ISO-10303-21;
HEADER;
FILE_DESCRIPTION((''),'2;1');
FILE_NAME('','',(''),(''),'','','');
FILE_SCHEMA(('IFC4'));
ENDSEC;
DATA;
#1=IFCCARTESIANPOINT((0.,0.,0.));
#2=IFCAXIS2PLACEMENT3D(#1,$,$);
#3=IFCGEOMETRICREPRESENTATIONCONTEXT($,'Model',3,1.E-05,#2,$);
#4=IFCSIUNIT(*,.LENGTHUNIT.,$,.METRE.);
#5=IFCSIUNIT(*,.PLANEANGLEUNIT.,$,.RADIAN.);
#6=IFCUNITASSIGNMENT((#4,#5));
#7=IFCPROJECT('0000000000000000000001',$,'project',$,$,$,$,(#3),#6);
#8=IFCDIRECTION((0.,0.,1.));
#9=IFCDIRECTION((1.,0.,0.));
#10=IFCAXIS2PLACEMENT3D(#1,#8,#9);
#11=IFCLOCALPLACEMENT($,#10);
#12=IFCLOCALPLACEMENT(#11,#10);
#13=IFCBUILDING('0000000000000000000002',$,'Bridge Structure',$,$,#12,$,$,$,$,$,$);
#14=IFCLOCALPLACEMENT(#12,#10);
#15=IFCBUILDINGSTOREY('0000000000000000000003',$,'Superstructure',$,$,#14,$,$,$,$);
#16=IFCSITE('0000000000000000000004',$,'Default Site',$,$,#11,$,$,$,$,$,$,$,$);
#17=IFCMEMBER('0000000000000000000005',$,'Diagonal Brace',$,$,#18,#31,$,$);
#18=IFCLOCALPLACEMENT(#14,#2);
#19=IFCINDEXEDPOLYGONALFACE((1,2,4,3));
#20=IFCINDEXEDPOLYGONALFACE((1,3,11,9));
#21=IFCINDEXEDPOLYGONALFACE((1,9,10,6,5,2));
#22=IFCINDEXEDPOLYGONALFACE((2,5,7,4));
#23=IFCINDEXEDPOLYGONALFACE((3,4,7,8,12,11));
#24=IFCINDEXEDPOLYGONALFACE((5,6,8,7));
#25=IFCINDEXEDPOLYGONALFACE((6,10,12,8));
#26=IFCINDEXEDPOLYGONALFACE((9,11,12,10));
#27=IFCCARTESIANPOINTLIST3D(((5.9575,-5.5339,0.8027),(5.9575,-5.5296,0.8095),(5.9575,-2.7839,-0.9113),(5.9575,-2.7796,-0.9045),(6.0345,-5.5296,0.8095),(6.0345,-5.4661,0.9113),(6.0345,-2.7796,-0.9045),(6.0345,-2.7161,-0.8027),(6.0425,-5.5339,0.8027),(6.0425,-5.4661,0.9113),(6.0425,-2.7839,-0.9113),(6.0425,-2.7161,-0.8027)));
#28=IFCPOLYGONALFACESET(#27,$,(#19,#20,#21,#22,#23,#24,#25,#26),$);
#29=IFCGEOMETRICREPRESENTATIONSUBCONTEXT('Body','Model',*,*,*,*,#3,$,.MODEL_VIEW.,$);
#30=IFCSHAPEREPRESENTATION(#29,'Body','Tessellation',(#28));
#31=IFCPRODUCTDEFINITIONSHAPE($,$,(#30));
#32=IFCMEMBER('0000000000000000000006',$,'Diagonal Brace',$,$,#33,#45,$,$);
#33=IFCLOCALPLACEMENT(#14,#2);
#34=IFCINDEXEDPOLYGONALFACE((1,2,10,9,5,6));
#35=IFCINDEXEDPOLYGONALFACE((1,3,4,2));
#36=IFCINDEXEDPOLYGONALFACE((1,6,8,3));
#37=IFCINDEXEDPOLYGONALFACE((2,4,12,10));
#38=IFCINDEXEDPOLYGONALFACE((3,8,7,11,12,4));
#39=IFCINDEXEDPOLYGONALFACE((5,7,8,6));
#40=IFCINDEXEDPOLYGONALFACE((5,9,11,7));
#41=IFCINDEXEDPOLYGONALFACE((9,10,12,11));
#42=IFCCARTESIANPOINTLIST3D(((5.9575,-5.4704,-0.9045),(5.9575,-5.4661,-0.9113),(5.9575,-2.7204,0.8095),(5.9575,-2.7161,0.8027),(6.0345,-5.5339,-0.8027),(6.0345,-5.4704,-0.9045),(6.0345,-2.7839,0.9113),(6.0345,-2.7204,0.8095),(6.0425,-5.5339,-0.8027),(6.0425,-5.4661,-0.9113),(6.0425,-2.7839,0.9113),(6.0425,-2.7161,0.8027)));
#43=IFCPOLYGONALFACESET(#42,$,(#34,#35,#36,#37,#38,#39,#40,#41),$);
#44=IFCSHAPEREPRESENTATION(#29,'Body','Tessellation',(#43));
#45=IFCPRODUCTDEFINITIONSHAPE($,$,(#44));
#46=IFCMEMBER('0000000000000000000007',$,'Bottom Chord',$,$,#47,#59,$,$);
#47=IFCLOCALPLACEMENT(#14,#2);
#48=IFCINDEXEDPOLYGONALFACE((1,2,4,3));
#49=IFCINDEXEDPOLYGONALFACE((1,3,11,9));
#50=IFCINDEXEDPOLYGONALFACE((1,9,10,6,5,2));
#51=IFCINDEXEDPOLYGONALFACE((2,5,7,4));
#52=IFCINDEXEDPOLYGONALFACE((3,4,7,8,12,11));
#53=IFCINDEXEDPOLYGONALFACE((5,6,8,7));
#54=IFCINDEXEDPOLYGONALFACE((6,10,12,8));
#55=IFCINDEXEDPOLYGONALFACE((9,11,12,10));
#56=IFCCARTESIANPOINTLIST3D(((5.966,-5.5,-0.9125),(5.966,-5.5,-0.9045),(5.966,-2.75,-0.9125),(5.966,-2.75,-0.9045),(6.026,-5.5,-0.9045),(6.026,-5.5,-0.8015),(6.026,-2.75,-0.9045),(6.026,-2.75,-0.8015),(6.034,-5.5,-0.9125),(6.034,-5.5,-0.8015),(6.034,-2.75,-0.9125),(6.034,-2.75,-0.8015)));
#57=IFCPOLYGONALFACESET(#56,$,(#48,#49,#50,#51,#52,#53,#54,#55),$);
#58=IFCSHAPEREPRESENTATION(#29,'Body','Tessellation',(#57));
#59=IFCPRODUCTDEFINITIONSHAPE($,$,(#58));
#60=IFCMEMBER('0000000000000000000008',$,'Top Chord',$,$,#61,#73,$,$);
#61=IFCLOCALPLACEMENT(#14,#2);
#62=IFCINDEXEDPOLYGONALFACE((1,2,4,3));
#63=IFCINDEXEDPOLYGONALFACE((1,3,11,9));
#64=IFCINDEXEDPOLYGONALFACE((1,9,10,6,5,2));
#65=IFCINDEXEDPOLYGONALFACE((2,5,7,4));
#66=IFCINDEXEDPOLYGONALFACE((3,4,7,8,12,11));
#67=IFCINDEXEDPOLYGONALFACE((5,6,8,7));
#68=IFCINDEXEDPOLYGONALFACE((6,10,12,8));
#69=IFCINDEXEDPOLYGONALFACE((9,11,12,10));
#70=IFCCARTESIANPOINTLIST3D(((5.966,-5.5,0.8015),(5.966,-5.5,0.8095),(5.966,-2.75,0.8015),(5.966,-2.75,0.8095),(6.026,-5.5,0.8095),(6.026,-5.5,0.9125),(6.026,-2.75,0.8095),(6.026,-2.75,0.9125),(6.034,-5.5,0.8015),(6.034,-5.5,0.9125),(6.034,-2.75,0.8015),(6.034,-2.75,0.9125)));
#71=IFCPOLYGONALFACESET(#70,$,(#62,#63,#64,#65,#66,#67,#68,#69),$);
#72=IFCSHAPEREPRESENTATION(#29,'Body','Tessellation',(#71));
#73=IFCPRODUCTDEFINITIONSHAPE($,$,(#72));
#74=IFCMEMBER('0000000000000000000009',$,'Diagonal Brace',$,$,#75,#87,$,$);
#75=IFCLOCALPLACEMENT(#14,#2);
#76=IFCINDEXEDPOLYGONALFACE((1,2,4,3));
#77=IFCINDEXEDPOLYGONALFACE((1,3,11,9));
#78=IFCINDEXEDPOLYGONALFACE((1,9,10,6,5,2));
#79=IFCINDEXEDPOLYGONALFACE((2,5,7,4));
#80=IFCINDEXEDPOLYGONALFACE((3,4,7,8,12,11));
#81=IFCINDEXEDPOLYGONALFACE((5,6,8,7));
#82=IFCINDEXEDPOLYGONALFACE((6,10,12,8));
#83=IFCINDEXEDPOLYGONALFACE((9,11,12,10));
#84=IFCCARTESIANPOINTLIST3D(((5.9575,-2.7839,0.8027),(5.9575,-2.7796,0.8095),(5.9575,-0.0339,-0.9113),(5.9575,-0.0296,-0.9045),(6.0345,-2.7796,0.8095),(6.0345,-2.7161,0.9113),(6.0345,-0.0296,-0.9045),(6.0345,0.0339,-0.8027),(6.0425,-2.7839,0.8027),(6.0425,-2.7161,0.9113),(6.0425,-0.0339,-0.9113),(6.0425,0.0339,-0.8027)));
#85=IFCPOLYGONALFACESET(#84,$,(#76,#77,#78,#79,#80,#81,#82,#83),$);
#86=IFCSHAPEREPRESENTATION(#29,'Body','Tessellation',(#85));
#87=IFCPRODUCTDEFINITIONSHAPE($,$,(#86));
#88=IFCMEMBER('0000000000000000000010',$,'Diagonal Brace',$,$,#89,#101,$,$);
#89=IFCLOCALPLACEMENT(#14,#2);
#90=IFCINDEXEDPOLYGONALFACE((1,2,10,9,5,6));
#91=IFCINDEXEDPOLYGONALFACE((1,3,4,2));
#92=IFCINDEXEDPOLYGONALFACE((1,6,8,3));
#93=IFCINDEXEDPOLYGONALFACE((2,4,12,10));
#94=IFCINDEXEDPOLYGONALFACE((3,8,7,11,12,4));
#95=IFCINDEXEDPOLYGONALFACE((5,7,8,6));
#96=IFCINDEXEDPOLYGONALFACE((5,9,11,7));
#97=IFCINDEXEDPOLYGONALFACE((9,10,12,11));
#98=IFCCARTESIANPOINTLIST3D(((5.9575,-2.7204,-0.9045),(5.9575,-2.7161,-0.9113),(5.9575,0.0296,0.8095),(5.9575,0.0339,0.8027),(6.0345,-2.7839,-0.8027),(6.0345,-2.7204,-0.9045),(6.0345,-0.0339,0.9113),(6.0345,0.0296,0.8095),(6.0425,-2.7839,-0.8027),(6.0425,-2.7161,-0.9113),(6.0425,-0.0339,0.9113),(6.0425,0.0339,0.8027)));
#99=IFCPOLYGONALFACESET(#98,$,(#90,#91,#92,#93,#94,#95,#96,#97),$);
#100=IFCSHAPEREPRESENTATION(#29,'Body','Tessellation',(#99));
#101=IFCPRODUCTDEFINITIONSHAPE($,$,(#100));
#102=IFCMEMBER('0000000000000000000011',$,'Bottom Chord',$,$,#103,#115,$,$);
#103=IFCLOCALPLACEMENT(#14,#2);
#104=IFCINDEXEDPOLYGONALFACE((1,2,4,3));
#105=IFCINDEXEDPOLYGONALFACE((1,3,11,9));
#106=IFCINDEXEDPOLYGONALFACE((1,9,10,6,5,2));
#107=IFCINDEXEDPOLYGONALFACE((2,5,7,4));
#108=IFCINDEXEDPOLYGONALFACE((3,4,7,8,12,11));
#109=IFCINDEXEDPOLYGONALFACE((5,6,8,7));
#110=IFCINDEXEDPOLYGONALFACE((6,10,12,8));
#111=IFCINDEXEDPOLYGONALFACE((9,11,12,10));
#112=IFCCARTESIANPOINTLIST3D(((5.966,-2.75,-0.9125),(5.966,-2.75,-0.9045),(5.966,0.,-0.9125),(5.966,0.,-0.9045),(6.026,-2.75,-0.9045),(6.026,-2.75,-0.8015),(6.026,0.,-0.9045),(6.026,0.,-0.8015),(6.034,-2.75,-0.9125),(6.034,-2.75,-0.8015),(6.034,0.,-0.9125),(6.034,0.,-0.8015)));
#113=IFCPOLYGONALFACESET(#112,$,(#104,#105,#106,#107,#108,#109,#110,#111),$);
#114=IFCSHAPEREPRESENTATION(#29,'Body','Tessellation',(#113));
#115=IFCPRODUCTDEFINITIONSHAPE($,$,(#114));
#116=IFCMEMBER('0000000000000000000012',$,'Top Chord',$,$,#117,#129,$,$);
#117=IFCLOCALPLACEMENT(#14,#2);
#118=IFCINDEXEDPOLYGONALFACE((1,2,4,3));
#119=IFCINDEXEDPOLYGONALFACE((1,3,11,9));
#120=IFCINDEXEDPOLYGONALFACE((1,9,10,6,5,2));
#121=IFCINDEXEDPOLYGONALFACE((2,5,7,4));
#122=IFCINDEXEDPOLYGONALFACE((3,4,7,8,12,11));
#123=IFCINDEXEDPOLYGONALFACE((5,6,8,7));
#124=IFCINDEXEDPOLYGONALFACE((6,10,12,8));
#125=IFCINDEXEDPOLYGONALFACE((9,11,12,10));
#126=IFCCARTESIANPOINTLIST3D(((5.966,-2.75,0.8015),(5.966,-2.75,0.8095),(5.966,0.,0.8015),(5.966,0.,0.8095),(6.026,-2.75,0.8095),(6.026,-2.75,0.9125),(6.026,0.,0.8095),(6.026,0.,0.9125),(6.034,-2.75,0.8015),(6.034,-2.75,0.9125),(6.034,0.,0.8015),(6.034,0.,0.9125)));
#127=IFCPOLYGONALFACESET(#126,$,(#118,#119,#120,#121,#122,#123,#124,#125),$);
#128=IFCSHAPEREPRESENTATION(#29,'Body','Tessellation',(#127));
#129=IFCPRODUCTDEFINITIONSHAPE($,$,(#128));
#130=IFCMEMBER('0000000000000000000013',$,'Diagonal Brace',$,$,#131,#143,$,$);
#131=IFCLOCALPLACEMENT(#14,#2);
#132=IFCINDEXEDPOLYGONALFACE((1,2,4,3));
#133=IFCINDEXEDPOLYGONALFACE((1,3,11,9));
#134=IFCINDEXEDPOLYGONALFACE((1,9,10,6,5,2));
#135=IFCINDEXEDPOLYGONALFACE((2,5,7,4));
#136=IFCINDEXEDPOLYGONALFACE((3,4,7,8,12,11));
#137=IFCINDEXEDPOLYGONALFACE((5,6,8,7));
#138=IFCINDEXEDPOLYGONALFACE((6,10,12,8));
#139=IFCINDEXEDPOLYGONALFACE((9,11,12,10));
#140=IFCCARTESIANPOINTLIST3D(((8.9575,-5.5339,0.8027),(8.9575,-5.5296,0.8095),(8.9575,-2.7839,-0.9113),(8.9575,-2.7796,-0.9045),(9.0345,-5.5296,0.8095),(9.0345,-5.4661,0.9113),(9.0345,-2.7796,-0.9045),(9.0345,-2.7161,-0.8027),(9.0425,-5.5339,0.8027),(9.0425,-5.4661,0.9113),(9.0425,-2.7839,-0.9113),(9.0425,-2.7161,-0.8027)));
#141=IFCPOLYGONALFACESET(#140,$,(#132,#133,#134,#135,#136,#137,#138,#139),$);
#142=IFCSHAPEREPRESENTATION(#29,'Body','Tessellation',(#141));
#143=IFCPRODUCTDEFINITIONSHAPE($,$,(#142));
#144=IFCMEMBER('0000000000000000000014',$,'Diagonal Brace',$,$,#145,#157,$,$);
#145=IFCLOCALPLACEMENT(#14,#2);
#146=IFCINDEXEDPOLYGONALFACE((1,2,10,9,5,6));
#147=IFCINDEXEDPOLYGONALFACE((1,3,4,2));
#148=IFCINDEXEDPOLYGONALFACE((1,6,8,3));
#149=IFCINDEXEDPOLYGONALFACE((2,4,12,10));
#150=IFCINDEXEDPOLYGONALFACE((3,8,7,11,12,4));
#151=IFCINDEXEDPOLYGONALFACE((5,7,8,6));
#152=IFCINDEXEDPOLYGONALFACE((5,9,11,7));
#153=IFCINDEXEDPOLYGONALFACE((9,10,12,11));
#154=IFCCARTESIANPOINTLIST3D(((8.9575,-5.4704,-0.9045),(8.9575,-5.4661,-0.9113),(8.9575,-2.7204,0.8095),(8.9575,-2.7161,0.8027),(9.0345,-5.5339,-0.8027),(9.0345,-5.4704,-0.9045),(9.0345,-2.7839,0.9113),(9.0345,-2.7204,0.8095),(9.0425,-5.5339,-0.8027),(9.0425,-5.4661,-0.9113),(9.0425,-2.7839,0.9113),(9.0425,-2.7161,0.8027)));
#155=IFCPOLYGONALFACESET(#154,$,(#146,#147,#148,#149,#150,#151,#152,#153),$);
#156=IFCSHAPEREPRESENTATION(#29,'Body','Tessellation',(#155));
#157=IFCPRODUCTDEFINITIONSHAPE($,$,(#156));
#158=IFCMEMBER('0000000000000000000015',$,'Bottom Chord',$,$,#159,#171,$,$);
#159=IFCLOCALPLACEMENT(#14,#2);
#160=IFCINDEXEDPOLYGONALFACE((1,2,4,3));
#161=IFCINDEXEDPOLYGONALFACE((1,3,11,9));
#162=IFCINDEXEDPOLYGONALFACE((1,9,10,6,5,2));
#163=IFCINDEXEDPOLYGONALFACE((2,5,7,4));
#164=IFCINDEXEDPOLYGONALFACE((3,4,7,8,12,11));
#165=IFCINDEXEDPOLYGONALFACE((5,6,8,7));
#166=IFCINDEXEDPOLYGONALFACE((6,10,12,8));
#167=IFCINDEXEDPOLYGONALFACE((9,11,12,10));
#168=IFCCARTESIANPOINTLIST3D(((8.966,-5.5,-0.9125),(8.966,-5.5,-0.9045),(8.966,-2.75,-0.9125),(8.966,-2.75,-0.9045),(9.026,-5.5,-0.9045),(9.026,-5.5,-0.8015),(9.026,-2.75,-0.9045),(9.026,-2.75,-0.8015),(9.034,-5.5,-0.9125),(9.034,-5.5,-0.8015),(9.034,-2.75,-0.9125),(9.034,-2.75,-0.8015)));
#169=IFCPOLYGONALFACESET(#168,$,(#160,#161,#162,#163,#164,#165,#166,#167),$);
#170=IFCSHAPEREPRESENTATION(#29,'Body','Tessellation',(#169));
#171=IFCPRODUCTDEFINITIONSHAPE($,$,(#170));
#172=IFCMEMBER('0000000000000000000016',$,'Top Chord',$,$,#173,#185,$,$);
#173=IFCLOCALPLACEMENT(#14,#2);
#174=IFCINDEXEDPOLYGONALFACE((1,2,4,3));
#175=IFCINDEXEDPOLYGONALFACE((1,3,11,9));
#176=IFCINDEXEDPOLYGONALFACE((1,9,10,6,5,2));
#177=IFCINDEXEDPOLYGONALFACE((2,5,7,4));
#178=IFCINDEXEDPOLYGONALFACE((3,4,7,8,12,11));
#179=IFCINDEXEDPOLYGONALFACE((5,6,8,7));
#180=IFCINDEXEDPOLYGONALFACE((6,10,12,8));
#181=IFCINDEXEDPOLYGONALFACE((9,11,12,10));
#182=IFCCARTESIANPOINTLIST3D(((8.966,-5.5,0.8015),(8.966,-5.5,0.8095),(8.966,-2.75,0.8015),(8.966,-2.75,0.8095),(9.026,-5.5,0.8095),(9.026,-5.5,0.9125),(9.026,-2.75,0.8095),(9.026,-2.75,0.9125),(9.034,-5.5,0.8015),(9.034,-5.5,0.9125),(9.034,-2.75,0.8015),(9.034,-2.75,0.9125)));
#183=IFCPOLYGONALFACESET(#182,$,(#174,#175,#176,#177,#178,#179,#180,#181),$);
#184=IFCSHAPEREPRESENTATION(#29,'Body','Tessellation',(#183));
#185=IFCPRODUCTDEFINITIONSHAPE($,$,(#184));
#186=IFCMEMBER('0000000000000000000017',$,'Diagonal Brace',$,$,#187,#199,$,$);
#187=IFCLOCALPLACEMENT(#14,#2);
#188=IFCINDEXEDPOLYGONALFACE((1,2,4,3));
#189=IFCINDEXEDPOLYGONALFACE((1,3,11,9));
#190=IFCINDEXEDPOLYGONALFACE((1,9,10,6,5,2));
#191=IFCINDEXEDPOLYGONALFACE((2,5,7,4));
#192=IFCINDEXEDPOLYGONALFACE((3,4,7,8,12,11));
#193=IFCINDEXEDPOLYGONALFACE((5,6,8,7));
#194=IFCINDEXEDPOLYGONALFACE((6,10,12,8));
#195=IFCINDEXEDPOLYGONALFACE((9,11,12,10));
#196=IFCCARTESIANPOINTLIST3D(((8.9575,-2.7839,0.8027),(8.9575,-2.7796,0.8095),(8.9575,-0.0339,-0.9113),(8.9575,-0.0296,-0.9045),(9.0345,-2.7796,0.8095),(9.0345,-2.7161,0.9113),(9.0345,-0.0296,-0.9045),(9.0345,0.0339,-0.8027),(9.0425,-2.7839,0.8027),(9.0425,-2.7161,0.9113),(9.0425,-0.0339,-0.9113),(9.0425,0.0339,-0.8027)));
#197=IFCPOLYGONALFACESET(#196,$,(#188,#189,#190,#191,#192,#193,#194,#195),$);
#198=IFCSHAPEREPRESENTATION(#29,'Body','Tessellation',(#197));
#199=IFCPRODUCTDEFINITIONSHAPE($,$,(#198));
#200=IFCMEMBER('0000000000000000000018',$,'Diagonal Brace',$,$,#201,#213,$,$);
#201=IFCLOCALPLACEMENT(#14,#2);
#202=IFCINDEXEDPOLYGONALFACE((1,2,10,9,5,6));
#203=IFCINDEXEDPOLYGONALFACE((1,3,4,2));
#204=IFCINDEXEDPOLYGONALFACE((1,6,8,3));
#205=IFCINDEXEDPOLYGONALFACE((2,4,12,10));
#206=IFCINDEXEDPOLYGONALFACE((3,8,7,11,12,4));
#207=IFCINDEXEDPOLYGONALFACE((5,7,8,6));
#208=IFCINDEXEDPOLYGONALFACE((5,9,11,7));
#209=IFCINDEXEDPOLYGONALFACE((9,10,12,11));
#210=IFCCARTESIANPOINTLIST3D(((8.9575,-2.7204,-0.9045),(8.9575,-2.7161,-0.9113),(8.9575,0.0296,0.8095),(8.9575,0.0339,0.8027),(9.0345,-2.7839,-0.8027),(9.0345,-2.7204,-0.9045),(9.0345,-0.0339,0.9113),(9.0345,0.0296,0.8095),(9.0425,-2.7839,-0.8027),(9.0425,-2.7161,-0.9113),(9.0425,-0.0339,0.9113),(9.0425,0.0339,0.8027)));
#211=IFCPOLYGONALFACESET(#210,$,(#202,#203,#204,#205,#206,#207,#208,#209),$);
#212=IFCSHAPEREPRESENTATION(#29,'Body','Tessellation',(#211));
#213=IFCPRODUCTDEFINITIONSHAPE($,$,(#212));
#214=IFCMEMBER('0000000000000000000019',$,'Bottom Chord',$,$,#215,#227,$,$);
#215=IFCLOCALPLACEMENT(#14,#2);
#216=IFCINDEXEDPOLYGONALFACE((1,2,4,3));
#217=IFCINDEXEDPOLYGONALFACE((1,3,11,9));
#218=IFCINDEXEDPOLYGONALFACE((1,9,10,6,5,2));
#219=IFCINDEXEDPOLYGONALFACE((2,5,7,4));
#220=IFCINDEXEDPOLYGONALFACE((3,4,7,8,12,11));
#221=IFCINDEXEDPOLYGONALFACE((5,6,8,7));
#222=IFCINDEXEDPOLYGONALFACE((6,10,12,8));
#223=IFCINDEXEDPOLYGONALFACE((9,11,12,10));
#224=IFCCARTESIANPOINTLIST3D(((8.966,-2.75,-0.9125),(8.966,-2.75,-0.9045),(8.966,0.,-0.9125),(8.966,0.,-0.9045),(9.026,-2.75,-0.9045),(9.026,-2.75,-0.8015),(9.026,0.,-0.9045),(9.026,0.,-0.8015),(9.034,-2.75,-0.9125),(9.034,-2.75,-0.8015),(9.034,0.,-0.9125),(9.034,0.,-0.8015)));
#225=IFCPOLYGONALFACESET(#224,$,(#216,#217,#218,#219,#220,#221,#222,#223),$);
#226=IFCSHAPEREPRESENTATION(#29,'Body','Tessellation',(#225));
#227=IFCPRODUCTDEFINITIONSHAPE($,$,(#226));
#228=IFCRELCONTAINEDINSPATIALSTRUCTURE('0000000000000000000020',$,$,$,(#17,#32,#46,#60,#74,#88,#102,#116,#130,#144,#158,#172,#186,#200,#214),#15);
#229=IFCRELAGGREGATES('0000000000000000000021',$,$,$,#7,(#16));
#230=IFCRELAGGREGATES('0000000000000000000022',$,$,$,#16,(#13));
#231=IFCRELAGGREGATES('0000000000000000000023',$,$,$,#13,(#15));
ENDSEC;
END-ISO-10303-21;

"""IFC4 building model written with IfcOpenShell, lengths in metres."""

from ifc_helpers import new_model, si_unit, frame, origin, origin_with_axes, origin_2d_with_axis, place, context, subcontext, project, spatial, l_section, extrude, element, save


model = new_model("IFC4")

# Units and contexts
model_context = context("Model", 3, precision=1e-05, world=origin())
body_context = subcontext(model_context, "Body", "Model", "MODEL_VIEW")
ifc_project = project(units=[si_unit("LENGTHUNIT", "METRE"), si_unit("PLANEANGLEUNIT", "RADIAN")], contexts=[model_context])

# Site, building, storey
site_placement = place(None, origin_with_axes())
site = spatial("IfcSite", under=ifc_project, at=site_placement, Name="Default Site")
building_placement = place(site_placement, origin_with_axes())
building = spatial("IfcBuilding", under=site, at=building_placement, Name="Bridge Structure")
storey_placement = place(building_placement, origin_with_axes())
storey = spatial("IfcBuildingStorey", under=building, at=storey_placement, Name="Superstructure")

# Members
for number, where, z_axis, x_axis, name in (
    (1, (6.0, -5.5, 0.857), (0.0, 0.848656, -0.528944), (-1.0, 0.0, 0.0), "Diagonal Brace"),
    (2, (6.0, -5.5, -0.857), (0.0, 0.848656, 0.528944), (-1.0, 0.0, 0.0), "Diagonal Brace"),
):
    element("IfcMember", number, at=place(storey_placement, frame(where, z_axis=z_axis, x_axis=x_axis)), inside=storey, Name=name, context=body_context, shape_type="SweptSolid", body=[
        extrude(l_section(Depth=0.128, Width=0.085, Thickness=0.008, at=origin_2d_with_axis()), origin_with_axes(), (0.0, 0.0, 1.0), 3.2404),
    ])
for number, where, z_axis, x_axis, name in (
    (3, (6.0, -5.5, -0.857), (0.0, 1.0, 0.0), (-1.0, 0.0, 0.0), "Bottom Chord"),
    (4, (6.0, -5.5, 0.857), (0.0, 1.0, 0.0), (-1.0, 0.0, 0.0), "Top Chord"),
):
    element("IfcMember", number, at=place(storey_placement, frame(where, z_axis=z_axis, x_axis=x_axis)), inside=storey, Name=name, context=body_context, shape_type="SweptSolid", body=[
        extrude(l_section(Depth=0.111, Width=0.068, Thickness=0.008, at=origin_2d_with_axis()), origin_with_axes(), (0.0, 0.0, 1.0), 2.75),
    ])
for number, where, z_axis, x_axis, name in (
    (5, (6.0, -2.75, 0.857), (0.0, 0.848656, -0.528944), (-1.0, 0.0, 0.0), "Diagonal Brace"),
    (6, (6.0, -2.75, -0.857), (0.0, 0.848656, 0.528944), (-1.0, 0.0, 0.0), "Diagonal Brace"),
):
    element("IfcMember", number, at=place(storey_placement, frame(where, z_axis=z_axis, x_axis=x_axis)), inside=storey, Name=name, context=body_context, shape_type="SweptSolid", body=[
        extrude(l_section(Depth=0.128, Width=0.085, Thickness=0.008, at=origin_2d_with_axis()), origin_with_axes(), (0.0, 0.0, 1.0), 3.2404),
    ])
for number, where, z_axis, x_axis, name in (
    (7, (6.0, -2.75, -0.857), (0.0, 1.0, 0.0), (-1.0, 0.0, 0.0), "Bottom Chord"),
    (8, (6.0, -2.75, 0.857), (0.0, 1.0, 0.0), (-1.0, 0.0, 0.0), "Top Chord"),
):
    element("IfcMember", number, at=place(storey_placement, frame(where, z_axis=z_axis, x_axis=x_axis)), inside=storey, Name=name, context=body_context, shape_type="SweptSolid", body=[
        extrude(l_section(Depth=0.111, Width=0.068, Thickness=0.008, at=origin_2d_with_axis()), origin_with_axes(), (0.0, 0.0, 1.0), 2.75),
    ])
for number, where, z_axis, x_axis, name in (
    (9, (9.0, -5.5, 0.857), (0.0, 0.848656, -0.528944), (-1.0, 0.0, 0.0), "Diagonal Brace"),
    (10, (9.0, -5.5, -0.857), (0.0, 0.848656, 0.528944), (-1.0, 0.0, 0.0), "Diagonal Brace"),
):
    element("IfcMember", number, at=place(storey_placement, frame(where, z_axis=z_axis, x_axis=x_axis)), inside=storey, Name=name, context=body_context, shape_type="SweptSolid", body=[
        extrude(l_section(Depth=0.128, Width=0.085, Thickness=0.008, at=origin_2d_with_axis()), origin_with_axes(), (0.0, 0.0, 1.0), 3.2404),
    ])
for number, where, z_axis, x_axis, name in (
    (11, (9.0, -5.5, -0.857), (0.0, 1.0, 0.0), (-1.0, 0.0, 0.0), "Bottom Chord"),
    (12, (9.0, -5.5, 0.857), (0.0, 1.0, 0.0), (-1.0, 0.0, 0.0), "Top Chord"),
):
    element("IfcMember", number, at=place(storey_placement, frame(where, z_axis=z_axis, x_axis=x_axis)), inside=storey, Name=name, context=body_context, shape_type="SweptSolid", body=[
        extrude(l_section(Depth=0.111, Width=0.068, Thickness=0.008, at=origin_2d_with_axis()), origin_with_axes(), (0.0, 0.0, 1.0), 2.75),
    ])
for number, where, z_axis, x_axis, name in (
    (13, (9.0, -2.75, 0.857), (0.0, 0.848656, -0.528944), (-1.0, 0.0, 0.0), "Diagonal Brace"),
    (14, (9.0, -2.75, -0.857), (0.0, 0.848656, 0.528944), (-1.0, 0.0, 0.0), "Diagonal Brace"),
):
    element("IfcMember", number, at=place(storey_placement, frame(where, z_axis=z_axis, x_axis=x_axis)), inside=storey, Name=name, context=body_context, shape_type="SweptSolid", body=[
        extrude(l_section(Depth=0.128, Width=0.085, Thickness=0.008, at=origin_2d_with_axis()), origin_with_axes(), (0.0, 0.0, 1.0), 3.2404),
    ])
for number, where, z_axis, x_axis, name in (
    (15, (9.0, -2.75, -0.857), (0.0, 1.0, 0.0), (-1.0, 0.0, 0.0), "Bottom Chord"),
):
    element("IfcMember", number, at=place(storey_placement, frame(where, z_axis=z_axis, x_axis=x_axis)), inside=storey, Name=name, context=body_context, shape_type="SweptSolid", body=[
        extrude(l_section(Depth=0.111, Width=0.068, Thickness=0.008, at=origin_2d_with_axis()), origin_with_axes(), (0.0, 0.0, 1.0), 2.75),
    ])

save(model, "model.ifc")
